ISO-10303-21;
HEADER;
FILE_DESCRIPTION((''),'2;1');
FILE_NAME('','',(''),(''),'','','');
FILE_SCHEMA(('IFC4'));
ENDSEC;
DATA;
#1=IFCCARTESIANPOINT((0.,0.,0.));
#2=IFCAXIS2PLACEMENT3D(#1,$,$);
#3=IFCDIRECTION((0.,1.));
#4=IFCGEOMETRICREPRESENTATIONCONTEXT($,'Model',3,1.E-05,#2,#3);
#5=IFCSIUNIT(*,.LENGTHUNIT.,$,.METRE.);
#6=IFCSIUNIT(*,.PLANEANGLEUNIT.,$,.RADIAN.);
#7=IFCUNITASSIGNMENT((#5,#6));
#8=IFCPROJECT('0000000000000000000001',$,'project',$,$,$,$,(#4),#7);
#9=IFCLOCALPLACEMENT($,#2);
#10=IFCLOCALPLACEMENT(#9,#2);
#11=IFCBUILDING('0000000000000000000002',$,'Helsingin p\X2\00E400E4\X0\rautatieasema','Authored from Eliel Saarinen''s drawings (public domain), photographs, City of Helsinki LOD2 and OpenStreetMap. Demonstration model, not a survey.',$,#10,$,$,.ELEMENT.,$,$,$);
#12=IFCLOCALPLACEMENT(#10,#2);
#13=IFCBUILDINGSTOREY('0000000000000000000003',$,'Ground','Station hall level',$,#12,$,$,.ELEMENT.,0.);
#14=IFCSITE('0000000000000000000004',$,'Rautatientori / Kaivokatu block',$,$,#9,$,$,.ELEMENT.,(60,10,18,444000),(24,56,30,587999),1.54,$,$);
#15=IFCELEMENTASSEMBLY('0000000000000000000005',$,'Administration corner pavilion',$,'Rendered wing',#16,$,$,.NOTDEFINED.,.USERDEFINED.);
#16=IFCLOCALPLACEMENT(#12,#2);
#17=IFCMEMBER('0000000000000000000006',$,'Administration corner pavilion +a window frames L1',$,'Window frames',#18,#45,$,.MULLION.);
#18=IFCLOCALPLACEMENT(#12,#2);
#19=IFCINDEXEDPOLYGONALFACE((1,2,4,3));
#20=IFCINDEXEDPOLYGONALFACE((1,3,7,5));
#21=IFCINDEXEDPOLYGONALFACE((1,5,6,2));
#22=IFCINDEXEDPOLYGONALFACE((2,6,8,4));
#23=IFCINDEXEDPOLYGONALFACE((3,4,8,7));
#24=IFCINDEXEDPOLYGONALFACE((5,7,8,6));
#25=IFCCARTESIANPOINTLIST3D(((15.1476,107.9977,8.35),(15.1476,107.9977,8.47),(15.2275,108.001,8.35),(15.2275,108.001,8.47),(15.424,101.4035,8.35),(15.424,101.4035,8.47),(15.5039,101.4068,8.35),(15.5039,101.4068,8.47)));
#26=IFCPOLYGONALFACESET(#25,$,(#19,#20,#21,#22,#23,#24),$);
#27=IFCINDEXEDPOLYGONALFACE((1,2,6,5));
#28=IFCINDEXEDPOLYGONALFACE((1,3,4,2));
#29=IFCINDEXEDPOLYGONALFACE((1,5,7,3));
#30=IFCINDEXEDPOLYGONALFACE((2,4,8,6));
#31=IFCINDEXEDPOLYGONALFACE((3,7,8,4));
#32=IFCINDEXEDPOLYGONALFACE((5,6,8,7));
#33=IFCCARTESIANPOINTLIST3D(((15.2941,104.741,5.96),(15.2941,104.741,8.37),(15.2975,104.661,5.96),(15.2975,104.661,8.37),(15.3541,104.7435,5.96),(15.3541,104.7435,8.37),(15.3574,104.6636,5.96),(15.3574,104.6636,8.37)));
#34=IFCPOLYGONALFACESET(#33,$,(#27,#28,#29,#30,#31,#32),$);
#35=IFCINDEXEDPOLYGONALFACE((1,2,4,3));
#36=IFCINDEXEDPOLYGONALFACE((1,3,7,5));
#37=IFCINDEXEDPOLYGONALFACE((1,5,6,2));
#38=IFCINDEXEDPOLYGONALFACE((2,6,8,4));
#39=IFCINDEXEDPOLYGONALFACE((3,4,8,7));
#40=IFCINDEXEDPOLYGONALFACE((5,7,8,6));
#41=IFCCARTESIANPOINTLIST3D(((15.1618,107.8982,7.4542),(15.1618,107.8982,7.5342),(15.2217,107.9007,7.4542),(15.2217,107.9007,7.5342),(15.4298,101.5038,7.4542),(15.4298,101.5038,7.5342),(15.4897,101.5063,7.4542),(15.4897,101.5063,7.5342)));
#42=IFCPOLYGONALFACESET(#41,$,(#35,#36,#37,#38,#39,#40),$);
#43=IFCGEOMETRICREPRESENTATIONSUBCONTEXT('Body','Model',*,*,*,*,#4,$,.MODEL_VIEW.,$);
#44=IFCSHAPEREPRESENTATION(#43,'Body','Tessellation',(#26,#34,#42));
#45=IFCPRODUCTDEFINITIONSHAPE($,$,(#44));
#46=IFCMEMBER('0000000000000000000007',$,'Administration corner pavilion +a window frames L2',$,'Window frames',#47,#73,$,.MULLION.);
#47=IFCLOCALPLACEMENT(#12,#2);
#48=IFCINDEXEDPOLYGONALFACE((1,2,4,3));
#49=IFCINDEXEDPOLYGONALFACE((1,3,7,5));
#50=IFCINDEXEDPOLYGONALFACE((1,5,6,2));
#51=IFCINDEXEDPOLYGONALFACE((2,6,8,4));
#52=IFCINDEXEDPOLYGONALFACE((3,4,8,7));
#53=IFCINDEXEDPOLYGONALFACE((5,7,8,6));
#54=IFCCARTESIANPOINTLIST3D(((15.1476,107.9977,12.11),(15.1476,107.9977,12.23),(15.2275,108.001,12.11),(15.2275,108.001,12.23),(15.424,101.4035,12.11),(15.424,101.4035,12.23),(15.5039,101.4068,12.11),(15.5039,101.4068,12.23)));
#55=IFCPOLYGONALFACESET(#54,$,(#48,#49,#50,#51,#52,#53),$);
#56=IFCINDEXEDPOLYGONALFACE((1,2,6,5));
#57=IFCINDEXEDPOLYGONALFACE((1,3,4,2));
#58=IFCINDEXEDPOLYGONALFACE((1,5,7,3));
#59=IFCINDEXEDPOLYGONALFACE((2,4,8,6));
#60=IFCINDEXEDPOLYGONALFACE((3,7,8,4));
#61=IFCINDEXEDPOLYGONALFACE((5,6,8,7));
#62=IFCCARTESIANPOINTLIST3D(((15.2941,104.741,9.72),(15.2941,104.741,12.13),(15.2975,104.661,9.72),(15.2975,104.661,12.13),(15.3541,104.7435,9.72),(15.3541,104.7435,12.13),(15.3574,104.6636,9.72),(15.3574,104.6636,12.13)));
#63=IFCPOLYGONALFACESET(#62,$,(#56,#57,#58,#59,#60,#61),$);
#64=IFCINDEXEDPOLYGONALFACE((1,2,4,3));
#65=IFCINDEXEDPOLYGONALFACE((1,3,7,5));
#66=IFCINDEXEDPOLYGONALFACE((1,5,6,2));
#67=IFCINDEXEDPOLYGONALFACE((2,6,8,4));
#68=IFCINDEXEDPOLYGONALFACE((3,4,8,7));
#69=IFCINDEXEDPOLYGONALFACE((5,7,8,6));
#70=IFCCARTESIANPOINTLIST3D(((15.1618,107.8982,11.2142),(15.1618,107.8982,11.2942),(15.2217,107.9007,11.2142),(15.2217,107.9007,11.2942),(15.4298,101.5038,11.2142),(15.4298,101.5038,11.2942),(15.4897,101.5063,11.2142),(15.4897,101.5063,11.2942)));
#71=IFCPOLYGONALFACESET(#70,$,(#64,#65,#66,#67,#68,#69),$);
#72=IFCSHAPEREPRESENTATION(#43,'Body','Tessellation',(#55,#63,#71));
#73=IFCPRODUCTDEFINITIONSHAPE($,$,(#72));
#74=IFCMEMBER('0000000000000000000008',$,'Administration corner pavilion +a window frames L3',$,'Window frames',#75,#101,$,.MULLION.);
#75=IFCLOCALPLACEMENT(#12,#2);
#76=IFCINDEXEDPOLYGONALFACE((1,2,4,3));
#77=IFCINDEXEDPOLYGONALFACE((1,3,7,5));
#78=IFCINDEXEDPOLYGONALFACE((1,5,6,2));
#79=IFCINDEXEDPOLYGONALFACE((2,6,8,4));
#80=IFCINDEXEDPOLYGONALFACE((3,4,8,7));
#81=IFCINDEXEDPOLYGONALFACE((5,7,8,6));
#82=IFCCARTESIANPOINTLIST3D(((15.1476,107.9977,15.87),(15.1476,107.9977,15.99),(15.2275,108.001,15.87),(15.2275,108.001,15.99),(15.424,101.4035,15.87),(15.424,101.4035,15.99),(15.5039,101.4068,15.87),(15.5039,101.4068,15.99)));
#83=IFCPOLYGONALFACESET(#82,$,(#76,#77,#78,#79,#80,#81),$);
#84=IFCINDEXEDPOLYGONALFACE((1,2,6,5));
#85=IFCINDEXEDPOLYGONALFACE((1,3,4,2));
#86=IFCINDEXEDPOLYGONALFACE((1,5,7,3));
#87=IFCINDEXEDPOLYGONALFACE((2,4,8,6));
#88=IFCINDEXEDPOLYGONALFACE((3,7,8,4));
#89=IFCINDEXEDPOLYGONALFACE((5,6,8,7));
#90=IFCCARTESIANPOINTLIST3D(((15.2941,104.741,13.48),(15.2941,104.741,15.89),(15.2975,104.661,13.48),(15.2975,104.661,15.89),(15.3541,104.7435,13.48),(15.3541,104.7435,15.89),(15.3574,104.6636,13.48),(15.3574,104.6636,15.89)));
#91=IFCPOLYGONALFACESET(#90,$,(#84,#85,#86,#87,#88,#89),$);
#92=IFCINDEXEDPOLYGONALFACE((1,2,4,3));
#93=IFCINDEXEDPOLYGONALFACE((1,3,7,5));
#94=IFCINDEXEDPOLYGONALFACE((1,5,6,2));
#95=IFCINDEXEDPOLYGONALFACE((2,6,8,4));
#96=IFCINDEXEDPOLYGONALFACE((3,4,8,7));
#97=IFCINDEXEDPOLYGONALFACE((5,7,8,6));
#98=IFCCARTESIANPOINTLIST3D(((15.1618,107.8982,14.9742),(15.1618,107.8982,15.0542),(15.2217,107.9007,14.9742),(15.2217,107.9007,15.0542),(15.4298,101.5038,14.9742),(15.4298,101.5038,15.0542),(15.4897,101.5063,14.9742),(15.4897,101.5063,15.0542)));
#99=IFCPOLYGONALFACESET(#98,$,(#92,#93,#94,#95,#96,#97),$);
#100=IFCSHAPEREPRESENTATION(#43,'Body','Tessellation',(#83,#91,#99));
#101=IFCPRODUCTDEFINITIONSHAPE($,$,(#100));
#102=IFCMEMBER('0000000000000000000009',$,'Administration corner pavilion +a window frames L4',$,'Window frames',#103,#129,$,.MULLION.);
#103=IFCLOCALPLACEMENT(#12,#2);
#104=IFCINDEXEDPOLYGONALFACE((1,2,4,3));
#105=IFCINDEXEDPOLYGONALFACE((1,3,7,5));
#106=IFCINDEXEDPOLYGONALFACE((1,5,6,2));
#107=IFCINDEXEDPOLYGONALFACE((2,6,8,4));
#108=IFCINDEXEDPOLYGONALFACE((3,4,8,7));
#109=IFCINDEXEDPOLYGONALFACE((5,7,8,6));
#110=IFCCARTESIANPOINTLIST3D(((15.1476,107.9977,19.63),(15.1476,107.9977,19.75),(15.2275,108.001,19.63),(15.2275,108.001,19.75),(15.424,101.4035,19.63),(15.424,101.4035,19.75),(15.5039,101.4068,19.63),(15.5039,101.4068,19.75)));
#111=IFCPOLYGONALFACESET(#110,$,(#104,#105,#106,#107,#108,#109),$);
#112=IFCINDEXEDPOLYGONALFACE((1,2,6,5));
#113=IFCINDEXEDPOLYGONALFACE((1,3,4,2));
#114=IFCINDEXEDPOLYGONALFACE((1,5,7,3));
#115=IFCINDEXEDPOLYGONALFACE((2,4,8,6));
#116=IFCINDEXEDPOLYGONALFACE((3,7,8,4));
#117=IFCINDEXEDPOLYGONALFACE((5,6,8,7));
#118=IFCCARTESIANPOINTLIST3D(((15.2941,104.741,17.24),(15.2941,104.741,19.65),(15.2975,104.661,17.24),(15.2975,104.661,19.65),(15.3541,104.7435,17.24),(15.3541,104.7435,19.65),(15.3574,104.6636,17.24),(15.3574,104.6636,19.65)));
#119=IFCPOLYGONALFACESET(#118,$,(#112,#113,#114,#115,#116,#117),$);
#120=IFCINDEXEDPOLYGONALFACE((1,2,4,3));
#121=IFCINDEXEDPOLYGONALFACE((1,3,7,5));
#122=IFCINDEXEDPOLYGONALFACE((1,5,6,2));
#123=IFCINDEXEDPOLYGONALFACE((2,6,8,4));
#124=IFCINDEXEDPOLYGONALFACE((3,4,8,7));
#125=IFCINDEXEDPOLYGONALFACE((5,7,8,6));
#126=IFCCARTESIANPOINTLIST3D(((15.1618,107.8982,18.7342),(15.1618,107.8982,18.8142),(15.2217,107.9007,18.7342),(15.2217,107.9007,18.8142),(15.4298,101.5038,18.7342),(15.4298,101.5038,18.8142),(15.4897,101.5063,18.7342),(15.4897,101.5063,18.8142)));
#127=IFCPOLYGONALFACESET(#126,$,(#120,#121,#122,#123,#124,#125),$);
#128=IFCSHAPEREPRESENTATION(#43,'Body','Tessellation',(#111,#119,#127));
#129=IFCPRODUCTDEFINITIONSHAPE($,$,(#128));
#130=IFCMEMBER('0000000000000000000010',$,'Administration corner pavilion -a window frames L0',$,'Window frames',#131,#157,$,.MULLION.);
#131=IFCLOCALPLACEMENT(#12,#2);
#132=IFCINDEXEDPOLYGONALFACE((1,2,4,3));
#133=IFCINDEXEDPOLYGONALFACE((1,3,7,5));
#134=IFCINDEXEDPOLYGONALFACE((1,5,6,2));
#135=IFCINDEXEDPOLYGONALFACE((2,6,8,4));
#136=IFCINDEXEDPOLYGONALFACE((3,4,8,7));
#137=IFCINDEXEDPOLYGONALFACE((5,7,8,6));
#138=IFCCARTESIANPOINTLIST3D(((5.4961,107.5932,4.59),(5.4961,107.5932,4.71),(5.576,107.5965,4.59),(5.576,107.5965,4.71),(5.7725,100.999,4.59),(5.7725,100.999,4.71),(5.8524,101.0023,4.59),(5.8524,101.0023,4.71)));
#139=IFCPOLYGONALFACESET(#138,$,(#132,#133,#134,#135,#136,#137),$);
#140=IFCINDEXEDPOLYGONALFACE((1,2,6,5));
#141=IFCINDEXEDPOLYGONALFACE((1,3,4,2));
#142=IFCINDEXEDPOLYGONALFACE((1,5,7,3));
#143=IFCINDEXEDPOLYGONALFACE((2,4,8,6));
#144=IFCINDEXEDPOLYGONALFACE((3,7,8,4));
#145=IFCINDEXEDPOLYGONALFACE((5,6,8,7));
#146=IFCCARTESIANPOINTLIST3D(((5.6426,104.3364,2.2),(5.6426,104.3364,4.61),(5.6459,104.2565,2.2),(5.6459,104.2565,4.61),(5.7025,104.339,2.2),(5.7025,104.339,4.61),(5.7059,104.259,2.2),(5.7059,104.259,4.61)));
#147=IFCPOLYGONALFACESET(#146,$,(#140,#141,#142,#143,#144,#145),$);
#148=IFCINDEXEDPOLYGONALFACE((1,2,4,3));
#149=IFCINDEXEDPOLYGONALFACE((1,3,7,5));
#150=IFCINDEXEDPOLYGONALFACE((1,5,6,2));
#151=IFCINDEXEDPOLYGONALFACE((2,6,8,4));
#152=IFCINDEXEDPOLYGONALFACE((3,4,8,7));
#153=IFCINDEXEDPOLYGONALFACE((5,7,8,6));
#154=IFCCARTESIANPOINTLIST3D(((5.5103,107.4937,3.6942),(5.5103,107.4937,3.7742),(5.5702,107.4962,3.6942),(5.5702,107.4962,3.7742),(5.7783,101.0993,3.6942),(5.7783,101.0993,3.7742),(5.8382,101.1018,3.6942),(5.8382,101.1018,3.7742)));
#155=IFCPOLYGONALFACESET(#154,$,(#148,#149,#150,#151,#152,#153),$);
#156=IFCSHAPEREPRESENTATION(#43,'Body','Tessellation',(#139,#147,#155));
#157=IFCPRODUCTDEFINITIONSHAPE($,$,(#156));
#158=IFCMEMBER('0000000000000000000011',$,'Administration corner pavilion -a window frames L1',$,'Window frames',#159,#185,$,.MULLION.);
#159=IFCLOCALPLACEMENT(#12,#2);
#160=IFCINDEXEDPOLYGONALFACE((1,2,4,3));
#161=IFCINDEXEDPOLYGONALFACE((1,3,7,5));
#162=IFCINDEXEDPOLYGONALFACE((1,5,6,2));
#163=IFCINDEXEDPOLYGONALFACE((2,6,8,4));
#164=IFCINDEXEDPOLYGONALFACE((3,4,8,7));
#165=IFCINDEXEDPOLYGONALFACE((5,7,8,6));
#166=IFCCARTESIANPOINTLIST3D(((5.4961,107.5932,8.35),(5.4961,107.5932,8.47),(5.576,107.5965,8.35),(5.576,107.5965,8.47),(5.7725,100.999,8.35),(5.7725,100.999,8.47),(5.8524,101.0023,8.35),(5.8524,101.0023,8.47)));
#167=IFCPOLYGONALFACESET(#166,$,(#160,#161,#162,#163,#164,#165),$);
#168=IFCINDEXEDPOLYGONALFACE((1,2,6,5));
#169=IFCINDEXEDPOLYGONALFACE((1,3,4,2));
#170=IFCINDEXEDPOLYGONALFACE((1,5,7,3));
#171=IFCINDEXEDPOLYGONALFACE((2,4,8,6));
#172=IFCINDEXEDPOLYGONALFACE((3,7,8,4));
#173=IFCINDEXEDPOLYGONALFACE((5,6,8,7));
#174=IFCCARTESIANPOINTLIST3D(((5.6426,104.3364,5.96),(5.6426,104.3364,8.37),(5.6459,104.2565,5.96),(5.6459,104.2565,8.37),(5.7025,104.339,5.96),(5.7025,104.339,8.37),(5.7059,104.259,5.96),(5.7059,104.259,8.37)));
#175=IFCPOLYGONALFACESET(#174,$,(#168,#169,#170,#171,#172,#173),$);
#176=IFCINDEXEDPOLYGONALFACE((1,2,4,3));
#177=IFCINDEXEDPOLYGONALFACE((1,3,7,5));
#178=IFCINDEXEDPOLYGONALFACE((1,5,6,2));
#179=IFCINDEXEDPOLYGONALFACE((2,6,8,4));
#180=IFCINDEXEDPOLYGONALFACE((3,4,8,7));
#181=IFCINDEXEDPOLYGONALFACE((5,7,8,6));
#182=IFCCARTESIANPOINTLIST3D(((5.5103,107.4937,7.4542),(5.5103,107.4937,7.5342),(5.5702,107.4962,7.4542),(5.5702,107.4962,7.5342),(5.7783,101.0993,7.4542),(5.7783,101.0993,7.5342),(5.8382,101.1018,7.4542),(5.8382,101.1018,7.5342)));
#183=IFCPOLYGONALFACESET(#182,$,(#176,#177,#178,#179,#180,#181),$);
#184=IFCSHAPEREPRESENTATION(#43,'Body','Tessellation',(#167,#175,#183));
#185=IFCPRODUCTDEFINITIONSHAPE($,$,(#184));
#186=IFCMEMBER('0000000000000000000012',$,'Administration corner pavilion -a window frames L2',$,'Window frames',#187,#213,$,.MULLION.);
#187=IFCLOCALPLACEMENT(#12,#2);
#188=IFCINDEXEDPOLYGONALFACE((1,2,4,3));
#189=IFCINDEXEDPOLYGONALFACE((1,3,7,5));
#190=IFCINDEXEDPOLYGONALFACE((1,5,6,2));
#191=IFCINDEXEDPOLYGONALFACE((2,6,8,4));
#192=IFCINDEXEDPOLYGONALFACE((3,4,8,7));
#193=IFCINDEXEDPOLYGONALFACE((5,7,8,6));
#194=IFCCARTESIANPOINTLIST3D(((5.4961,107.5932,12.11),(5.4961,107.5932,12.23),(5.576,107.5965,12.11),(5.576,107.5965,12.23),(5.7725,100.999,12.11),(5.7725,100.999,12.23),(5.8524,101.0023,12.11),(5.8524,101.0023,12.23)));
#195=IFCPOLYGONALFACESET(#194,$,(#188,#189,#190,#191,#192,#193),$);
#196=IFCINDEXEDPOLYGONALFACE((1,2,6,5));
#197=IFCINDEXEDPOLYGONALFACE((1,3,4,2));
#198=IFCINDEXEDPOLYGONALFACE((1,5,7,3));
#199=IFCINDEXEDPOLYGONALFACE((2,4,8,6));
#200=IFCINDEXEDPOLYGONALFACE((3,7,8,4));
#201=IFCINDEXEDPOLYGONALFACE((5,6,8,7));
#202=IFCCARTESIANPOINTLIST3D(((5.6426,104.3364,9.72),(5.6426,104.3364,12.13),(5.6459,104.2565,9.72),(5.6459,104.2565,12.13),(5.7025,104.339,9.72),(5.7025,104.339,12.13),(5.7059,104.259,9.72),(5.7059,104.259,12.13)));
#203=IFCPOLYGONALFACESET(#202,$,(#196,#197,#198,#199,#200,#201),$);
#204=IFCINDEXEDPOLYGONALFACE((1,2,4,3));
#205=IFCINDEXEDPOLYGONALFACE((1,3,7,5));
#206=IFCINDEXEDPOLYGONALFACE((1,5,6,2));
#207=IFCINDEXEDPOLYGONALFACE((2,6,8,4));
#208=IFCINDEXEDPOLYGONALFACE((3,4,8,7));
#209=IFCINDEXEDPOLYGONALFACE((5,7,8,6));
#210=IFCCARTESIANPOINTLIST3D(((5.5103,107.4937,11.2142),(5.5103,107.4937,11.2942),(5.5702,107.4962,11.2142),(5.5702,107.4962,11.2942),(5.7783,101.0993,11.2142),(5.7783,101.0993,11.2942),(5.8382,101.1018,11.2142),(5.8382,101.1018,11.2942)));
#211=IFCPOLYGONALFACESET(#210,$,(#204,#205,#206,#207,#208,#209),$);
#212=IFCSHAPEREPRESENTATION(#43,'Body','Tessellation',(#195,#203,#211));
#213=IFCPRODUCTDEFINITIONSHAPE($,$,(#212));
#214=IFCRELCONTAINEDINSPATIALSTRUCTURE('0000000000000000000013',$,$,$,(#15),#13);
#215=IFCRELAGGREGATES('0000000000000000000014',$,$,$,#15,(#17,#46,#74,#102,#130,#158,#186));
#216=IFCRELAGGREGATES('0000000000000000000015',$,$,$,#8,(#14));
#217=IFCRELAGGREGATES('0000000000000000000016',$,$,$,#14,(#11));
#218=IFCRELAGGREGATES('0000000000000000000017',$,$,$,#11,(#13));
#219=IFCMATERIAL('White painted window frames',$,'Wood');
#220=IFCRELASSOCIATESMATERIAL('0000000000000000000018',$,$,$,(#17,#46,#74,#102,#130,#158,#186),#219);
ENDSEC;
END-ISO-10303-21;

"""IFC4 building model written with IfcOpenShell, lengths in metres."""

from ifc_helpers import new_model, si_unit, direction, frame, frame_2d, origin, place, context, subcontext, project, spatial, rectangle, extrude, material, element, aggregate, save


model = new_model("IFC4")

# Units and contexts
model_context = context("Model", 3, precision=1e-05, world=origin(), true_north=direction((0.0, 1.0)))
body_context = subcontext(model_context, "Body", "Model", "MODEL_VIEW")
ifc_project = project(units=[si_unit("LENGTHUNIT", "METRE"), si_unit("PLANEANGLEUNIT", "RADIAN")], contexts=[model_context])

# Site, building, storey
site_placement = place(None, origin())
site = spatial("IfcSite", under=ifc_project, at=site_placement, Name="Rautatientori / Kaivokatu block", CompositionType="ELEMENT", RefLatitude=(60, 10, 18, 444000), RefLongitude=(24, 56, 30, 587999), RefElevation=1.54)
building_placement = place(site_placement, origin())
building = spatial("IfcBuilding", under=site, at=building_placement, Name="Helsingin päärautatieasema", Description="Authored from Eliel Saarinen's drawings (public domain), photographs, City of Helsinki LOD2 and OpenStreetMap. Demonstration model, not a survey.", CompositionType="ELEMENT")
storey_placement = place(building_placement, origin())
storey = spatial("IfcBuildingStorey", under=building, at=storey_placement, Name="Ground", Description="Station hall level", CompositionType="ELEMENT", Elevation=0.0)

# Element assembly, members
assembly_1_placement = place(building_placement, origin())
assembly_1 = element("IfcElementAssembly", 1, at=assembly_1_placement, inside=storey, Name="Administration corner pavilion", ObjectType="Rendered wing", AssemblyPlace="NOTDEFINED", PredefinedType="USERDEFINED")
ifc_material_1 = material(Name="White painted window frames", Category="Wood")
member_1_placement = place(building_placement, origin())
member_1 = element("IfcMember", 2, at=member_1_placement, material=ifc_material_1, Name="Administration corner pavilion +a window frames L1", ObjectType="Window frames", PredefinedType="MULLION", context=body_context, shape_type="SweptSolid", body=[
    extrude(rectangle(XDim=6.6, YDim=0.08, at=frame_2d((0.0, 0.0), x_axis=(-0.041876, 0.999123))), frame((15.3258, 104.7023, 8.35)), (0.0, 0.0, 1.0), 0.12),
    extrude(rectangle(XDim=0.08, YDim=0.06, at=frame_2d((0.0, 0.0), x_axis=(-0.041876, 0.999123))), frame((15.3258, 104.7023, 5.96)), (0.0, 0.0, 1.0), 2.41),
    extrude(rectangle(XDim=6.4, YDim=0.06, at=frame_2d((0.0, 0.0), x_axis=(-0.041876, 0.999123))), frame((15.3258, 104.7023, 7.4542)), (0.0, 0.0, 1.0), 0.08),
])
member_2_placement = place(building_placement, origin())
member_2 = element("IfcMember", 3, at=member_2_placement, material=ifc_material_1, Name="Administration corner pavilion +a window frames L2", ObjectType="Window frames", PredefinedType="MULLION", context=body_context, shape_type="SweptSolid", body=[
    extrude(rectangle(XDim=6.6, YDim=0.08, at=frame_2d((0.0, 0.0), x_axis=(-0.041876, 0.999123))), frame((15.3258, 104.7023, 12.11)), (0.0, 0.0, 1.0), 0.12),
    extrude(rectangle(XDim=0.08, YDim=0.06, at=frame_2d((0.0, 0.0), x_axis=(-0.041876, 0.999123))), frame((15.3258, 104.7023, 9.72)), (0.0, 0.0, 1.0), 2.41),
    extrude(rectangle(XDim=6.4, YDim=0.06, at=frame_2d((0.0, 0.0), x_axis=(-0.041876, 0.999123))), frame((15.3258, 104.7023, 11.2142)), (0.0, 0.0, 1.0), 0.08),
])
member_3_placement = place(building_placement, origin())
member_3 = element("IfcMember", 4, at=member_3_placement, material=ifc_material_1, Name="Administration corner pavilion +a window frames L3", ObjectType="Window frames", PredefinedType="MULLION", context=body_context, shape_type="SweptSolid", body=[
    extrude(rectangle(XDim=6.6, YDim=0.08, at=frame_2d((0.0, 0.0), x_axis=(-0.041876, 0.999123))), frame((15.3258, 104.7023, 15.87)), (0.0, 0.0, 1.0), 0.12),
    extrude(rectangle(XDim=0.08, YDim=0.06, at=frame_2d((0.0, 0.0), x_axis=(-0.041876, 0.999123))), frame((15.3258, 104.7023, 13.48)), (0.0, 0.0, 1.0), 2.41),
    extrude(rectangle(XDim=6.4, YDim=0.06, at=frame_2d((0.0, 0.0), x_axis=(-0.041876, 0.999123))), frame((15.3258, 104.7023, 14.9742)), (0.0, 0.0, 1.0), 0.08),
])
member_4_placement = place(building_placement, origin())
member_4 = element("IfcMember", 5, at=member_4_placement, material=ifc_material_1, Name="Administration corner pavilion +a window frames L4", ObjectType="Window frames", PredefinedType="MULLION", context=body_context, shape_type="SweptSolid", body=[
    extrude(rectangle(XDim=6.6, YDim=0.08, at=frame_2d((0.0, 0.0), x_axis=(-0.041876, 0.999123))), frame((15.3258, 104.7023, 19.63)), (0.0, 0.0, 1.0), 0.12),
    extrude(rectangle(XDim=0.08, YDim=0.06, at=frame_2d((0.0, 0.0), x_axis=(-0.041876, 0.999123))), frame((15.3258, 104.7023, 17.24)), (0.0, 0.0, 1.0), 2.41),
    extrude(rectangle(XDim=6.4, YDim=0.06, at=frame_2d((0.0, 0.0), x_axis=(-0.041876, 0.999123))), frame((15.3258, 104.7023, 18.7342)), (0.0, 0.0, 1.0), 0.08),
])
member_5_placement = place(building_placement, origin())
member_5 = element("IfcMember", 6, at=member_5_placement, material=ifc_material_1, Name="Administration corner pavilion -a window frames L0", ObjectType="Window frames", PredefinedType="MULLION", context=body_context, shape_type="SweptSolid", body=[
    extrude(rectangle(XDim=6.6, YDim=0.08, at=frame_2d((0.0, 0.0), x_axis=(0.041876, -0.999123))), frame((5.6742, 104.2977, 4.59)), (0.0, 0.0, 1.0), 0.12),
    extrude(rectangle(XDim=0.08, YDim=0.06, at=frame_2d((0.0, 0.0), x_axis=(0.041876, -0.999123))), frame((5.6742, 104.2977, 2.2)), (0.0, 0.0, 1.0), 2.41),
    extrude(rectangle(XDim=6.4, YDim=0.06, at=frame_2d((0.0, 0.0), x_axis=(0.041876, -0.999123))), frame((5.6742, 104.2977, 3.6942)), (0.0, 0.0, 1.0), 0.08),
])
member_6_placement = place(building_placement, origin())
member_6 = element("IfcMember", 7, at=member_6_placement, material=ifc_material_1, Name="Administration corner pavilion -a window frames L1", ObjectType="Window frames", PredefinedType="MULLION", context=body_context, shape_type="SweptSolid", body=[
    extrude(rectangle(XDim=6.6, YDim=0.08, at=frame_2d((0.0, 0.0), x_axis=(0.041876, -0.999123))), frame((5.6742, 104.2977, 8.35)), (0.0, 0.0, 1.0), 0.12),
    extrude(rectangle(XDim=0.08, YDim=0.06, at=frame_2d((0.0, 0.0), x_axis=(0.041876, -0.999123))), frame((5.6742, 104.2977, 5.96)), (0.0, 0.0, 1.0), 2.41),
    extrude(rectangle(XDim=6.4, YDim=0.06, at=frame_2d((0.0, 0.0), x_axis=(0.041876, -0.999123))), frame((5.6742, 104.2977, 7.4542)), (0.0, 0.0, 1.0), 0.08),
])
member_7_placement = place(building_placement, origin())
member_7 = element("IfcMember", 8, at=member_7_placement, material=ifc_material_1, Name="Administration corner pavilion -a window frames L2", ObjectType="Window frames", PredefinedType="MULLION", context=body_context, shape_type="SweptSolid", body=[
    extrude(rectangle(XDim=6.6, YDim=0.08, at=frame_2d((0.0, 0.0), x_axis=(0.041876, -0.999123))), frame((5.6742, 104.2977, 12.11)), (0.0, 0.0, 1.0), 0.12),
    extrude(rectangle(XDim=0.08, YDim=0.06, at=frame_2d((0.0, 0.0), x_axis=(0.041876, -0.999123))), frame((5.6742, 104.2977, 9.72)), (0.0, 0.0, 1.0), 2.41),
    extrude(rectangle(XDim=6.4, YDim=0.06, at=frame_2d((0.0, 0.0), x_axis=(0.041876, -0.999123))), frame((5.6742, 104.2977, 11.2142)), (0.0, 0.0, 1.0), 0.08),
])

aggregate(assembly_1, [member_1, member_2, member_3, member_4, member_5, member_6, member_7])

save(model, "model.ifc")
